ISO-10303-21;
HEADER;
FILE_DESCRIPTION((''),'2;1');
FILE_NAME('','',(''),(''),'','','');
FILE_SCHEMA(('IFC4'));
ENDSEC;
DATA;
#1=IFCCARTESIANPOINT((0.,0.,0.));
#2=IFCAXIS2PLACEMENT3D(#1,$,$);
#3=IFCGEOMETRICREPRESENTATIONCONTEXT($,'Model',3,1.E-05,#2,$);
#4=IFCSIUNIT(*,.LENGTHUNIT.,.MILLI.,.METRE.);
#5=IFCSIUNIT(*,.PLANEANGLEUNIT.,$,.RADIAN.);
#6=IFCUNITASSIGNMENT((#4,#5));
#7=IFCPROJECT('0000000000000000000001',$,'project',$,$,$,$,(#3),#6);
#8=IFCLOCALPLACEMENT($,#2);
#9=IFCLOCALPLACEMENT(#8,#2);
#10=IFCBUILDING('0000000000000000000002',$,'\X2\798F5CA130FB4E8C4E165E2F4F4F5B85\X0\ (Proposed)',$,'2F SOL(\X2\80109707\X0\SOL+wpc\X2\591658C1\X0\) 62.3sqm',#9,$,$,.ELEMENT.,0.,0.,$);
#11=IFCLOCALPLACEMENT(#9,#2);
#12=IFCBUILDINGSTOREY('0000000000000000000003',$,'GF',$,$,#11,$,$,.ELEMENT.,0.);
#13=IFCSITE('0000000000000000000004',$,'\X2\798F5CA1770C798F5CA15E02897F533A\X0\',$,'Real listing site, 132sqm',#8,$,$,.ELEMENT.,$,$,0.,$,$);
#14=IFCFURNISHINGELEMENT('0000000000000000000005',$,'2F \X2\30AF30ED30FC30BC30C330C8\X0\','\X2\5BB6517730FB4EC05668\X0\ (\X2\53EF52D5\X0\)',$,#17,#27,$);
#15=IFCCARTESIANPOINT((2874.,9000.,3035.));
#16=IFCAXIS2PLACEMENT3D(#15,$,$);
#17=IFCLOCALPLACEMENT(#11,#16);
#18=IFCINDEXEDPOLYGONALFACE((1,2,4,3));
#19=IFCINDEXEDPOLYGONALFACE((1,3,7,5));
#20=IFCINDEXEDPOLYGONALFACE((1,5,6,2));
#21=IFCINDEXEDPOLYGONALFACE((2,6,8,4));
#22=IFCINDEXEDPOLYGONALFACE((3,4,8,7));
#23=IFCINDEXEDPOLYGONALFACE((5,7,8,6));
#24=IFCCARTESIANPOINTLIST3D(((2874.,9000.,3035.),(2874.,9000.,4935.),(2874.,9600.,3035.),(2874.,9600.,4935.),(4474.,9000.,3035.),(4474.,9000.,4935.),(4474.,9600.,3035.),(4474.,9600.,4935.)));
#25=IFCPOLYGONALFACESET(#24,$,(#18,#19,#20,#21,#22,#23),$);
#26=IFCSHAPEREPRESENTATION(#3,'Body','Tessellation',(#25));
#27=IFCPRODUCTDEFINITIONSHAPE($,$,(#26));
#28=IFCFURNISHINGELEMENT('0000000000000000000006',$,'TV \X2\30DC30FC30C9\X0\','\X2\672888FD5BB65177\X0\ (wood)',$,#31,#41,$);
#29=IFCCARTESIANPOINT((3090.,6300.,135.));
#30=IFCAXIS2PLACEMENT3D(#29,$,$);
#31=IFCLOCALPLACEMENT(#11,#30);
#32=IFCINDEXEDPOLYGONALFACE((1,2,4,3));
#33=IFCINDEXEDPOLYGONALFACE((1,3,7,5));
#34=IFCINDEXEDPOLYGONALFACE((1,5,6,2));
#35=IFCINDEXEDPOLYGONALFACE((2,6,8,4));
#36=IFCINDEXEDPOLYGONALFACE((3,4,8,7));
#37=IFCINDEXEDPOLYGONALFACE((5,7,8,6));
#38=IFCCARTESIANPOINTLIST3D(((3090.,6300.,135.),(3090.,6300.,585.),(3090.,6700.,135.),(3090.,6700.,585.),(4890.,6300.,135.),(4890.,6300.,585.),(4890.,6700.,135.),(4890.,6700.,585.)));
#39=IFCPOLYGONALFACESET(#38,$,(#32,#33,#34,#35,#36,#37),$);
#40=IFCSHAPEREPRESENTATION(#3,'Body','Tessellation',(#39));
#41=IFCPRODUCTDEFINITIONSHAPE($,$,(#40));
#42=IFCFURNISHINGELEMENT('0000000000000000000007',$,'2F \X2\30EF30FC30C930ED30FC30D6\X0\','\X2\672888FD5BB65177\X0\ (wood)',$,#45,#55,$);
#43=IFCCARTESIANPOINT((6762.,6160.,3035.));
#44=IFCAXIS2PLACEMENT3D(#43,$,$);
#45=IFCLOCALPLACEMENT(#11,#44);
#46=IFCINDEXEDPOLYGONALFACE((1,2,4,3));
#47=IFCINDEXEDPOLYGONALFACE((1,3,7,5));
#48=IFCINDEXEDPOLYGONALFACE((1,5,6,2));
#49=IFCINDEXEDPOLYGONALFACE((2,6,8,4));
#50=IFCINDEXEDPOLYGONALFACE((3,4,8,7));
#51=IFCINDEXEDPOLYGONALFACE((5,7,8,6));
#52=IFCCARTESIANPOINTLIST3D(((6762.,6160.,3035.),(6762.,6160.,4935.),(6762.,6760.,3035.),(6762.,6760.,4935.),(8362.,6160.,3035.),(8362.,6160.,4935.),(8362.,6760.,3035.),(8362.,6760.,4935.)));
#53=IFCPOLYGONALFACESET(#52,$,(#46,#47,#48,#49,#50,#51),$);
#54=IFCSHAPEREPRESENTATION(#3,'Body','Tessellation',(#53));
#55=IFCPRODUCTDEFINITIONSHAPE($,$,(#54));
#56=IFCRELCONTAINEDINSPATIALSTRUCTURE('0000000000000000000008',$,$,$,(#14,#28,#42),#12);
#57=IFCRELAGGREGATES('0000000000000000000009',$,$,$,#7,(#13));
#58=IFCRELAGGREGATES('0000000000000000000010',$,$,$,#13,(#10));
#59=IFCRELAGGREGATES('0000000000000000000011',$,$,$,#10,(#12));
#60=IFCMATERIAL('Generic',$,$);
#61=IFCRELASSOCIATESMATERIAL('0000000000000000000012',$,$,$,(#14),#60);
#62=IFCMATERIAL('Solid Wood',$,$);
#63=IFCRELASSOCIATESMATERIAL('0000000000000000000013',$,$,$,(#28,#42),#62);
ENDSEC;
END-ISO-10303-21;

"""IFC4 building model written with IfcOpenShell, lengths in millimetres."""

from ifc_helpers import new_model, si_unit, frame, frame_2d, origin, place, context, project, spatial, rectangle, extrude, material, element, save


model = new_model("IFC4")

# Units and contexts
model_context = context("Model", 3, precision=1e-05, world=origin())
ifc_project = project(units=[si_unit("LENGTHUNIT", "METRE", prefix="MILLI"), si_unit("PLANEANGLEUNIT", "RADIAN")], contexts=[model_context])

# Site, building, storey
site_placement = place(None, origin())
site = spatial("IfcSite", under=ifc_project, at=site_placement, Name="福岡県福岡市西区", ObjectType="Real listing site, 132sqm", CompositionType="ELEMENT", RefElevation=0.0)
building_placement = place(site_placement, origin())
building = spatial("IfcBuilding", under=site, at=building_placement, Name="福岡・二世帯住宅 (Proposed)", ObjectType="2F SOL(耐震SOL+wpc外壁) 62.3sqm", CompositionType="ELEMENT", ElevationOfRefHeight=0.0, ElevationOfTerrain=0.0)
storey_placement = place(building_placement, origin())
storey = spatial("IfcBuildingStorey", under=building, at=storey_placement, Name="GF", CompositionType="ELEMENT", Elevation=0.0)

# Shared definitions
ifc_material_1 = material(Name="Solid Wood")

# Shared definitions
ifc_material_2 = material(Name="Generic")

# Furnishing elements
furnishing_1_placement = place(storey_placement, frame((2874.0, 9000.0, 3035.0)))
element("IfcFurnishingElement", 1, at=furnishing_1_placement, inside=storey, material=ifc_material_2, Name="2F クローゼット", Description="家具・什器 (可動)", context=model_context, shape_type="SweptSolid", body=[
    extrude(rectangle(XDim=1600.0, YDim=600.0, at=frame_2d((800.0, 300.0))), frame((2874.0, 9000.0, 3035.0)), (0.0, 0.0, 1.0), 1900.0),
])
furnishing_2_placement = place(storey_placement, frame((3090.0, 6300.0, 135.0)))
element("IfcFurnishingElement", 2, at=furnishing_2_placement, inside=storey, material=ifc_material_1, Name="TV ボード", Description="木製家具 (wood)", context=model_context, shape_type="SweptSolid", body=[
    extrude(rectangle(XDim=1800.0, YDim=400.0, at=frame_2d((900.0, 200.0))), frame((3090.0, 6300.0, 135.0)), (0.0, 0.0, 1.0), 450.0),
])
furnishing_3_placement = place(storey_placement, frame((6762.0, 6160.0, 3035.0)))
element("IfcFurnishingElement", 3, at=furnishing_3_placement, inside=storey, material=ifc_material_1, Name="2F ワードローブ", Description="木製家具 (wood)", context=model_context, shape_type="SweptSolid", body=[
    extrude(rectangle(XDim=1600.0, YDim=600.0, at=frame_2d((800.0, 300.0))), frame((6762.0, 6160.0, 3035.0)), (0.0, 0.0, 1.0), 1900.0),
])

save(model, "model.ifc")
